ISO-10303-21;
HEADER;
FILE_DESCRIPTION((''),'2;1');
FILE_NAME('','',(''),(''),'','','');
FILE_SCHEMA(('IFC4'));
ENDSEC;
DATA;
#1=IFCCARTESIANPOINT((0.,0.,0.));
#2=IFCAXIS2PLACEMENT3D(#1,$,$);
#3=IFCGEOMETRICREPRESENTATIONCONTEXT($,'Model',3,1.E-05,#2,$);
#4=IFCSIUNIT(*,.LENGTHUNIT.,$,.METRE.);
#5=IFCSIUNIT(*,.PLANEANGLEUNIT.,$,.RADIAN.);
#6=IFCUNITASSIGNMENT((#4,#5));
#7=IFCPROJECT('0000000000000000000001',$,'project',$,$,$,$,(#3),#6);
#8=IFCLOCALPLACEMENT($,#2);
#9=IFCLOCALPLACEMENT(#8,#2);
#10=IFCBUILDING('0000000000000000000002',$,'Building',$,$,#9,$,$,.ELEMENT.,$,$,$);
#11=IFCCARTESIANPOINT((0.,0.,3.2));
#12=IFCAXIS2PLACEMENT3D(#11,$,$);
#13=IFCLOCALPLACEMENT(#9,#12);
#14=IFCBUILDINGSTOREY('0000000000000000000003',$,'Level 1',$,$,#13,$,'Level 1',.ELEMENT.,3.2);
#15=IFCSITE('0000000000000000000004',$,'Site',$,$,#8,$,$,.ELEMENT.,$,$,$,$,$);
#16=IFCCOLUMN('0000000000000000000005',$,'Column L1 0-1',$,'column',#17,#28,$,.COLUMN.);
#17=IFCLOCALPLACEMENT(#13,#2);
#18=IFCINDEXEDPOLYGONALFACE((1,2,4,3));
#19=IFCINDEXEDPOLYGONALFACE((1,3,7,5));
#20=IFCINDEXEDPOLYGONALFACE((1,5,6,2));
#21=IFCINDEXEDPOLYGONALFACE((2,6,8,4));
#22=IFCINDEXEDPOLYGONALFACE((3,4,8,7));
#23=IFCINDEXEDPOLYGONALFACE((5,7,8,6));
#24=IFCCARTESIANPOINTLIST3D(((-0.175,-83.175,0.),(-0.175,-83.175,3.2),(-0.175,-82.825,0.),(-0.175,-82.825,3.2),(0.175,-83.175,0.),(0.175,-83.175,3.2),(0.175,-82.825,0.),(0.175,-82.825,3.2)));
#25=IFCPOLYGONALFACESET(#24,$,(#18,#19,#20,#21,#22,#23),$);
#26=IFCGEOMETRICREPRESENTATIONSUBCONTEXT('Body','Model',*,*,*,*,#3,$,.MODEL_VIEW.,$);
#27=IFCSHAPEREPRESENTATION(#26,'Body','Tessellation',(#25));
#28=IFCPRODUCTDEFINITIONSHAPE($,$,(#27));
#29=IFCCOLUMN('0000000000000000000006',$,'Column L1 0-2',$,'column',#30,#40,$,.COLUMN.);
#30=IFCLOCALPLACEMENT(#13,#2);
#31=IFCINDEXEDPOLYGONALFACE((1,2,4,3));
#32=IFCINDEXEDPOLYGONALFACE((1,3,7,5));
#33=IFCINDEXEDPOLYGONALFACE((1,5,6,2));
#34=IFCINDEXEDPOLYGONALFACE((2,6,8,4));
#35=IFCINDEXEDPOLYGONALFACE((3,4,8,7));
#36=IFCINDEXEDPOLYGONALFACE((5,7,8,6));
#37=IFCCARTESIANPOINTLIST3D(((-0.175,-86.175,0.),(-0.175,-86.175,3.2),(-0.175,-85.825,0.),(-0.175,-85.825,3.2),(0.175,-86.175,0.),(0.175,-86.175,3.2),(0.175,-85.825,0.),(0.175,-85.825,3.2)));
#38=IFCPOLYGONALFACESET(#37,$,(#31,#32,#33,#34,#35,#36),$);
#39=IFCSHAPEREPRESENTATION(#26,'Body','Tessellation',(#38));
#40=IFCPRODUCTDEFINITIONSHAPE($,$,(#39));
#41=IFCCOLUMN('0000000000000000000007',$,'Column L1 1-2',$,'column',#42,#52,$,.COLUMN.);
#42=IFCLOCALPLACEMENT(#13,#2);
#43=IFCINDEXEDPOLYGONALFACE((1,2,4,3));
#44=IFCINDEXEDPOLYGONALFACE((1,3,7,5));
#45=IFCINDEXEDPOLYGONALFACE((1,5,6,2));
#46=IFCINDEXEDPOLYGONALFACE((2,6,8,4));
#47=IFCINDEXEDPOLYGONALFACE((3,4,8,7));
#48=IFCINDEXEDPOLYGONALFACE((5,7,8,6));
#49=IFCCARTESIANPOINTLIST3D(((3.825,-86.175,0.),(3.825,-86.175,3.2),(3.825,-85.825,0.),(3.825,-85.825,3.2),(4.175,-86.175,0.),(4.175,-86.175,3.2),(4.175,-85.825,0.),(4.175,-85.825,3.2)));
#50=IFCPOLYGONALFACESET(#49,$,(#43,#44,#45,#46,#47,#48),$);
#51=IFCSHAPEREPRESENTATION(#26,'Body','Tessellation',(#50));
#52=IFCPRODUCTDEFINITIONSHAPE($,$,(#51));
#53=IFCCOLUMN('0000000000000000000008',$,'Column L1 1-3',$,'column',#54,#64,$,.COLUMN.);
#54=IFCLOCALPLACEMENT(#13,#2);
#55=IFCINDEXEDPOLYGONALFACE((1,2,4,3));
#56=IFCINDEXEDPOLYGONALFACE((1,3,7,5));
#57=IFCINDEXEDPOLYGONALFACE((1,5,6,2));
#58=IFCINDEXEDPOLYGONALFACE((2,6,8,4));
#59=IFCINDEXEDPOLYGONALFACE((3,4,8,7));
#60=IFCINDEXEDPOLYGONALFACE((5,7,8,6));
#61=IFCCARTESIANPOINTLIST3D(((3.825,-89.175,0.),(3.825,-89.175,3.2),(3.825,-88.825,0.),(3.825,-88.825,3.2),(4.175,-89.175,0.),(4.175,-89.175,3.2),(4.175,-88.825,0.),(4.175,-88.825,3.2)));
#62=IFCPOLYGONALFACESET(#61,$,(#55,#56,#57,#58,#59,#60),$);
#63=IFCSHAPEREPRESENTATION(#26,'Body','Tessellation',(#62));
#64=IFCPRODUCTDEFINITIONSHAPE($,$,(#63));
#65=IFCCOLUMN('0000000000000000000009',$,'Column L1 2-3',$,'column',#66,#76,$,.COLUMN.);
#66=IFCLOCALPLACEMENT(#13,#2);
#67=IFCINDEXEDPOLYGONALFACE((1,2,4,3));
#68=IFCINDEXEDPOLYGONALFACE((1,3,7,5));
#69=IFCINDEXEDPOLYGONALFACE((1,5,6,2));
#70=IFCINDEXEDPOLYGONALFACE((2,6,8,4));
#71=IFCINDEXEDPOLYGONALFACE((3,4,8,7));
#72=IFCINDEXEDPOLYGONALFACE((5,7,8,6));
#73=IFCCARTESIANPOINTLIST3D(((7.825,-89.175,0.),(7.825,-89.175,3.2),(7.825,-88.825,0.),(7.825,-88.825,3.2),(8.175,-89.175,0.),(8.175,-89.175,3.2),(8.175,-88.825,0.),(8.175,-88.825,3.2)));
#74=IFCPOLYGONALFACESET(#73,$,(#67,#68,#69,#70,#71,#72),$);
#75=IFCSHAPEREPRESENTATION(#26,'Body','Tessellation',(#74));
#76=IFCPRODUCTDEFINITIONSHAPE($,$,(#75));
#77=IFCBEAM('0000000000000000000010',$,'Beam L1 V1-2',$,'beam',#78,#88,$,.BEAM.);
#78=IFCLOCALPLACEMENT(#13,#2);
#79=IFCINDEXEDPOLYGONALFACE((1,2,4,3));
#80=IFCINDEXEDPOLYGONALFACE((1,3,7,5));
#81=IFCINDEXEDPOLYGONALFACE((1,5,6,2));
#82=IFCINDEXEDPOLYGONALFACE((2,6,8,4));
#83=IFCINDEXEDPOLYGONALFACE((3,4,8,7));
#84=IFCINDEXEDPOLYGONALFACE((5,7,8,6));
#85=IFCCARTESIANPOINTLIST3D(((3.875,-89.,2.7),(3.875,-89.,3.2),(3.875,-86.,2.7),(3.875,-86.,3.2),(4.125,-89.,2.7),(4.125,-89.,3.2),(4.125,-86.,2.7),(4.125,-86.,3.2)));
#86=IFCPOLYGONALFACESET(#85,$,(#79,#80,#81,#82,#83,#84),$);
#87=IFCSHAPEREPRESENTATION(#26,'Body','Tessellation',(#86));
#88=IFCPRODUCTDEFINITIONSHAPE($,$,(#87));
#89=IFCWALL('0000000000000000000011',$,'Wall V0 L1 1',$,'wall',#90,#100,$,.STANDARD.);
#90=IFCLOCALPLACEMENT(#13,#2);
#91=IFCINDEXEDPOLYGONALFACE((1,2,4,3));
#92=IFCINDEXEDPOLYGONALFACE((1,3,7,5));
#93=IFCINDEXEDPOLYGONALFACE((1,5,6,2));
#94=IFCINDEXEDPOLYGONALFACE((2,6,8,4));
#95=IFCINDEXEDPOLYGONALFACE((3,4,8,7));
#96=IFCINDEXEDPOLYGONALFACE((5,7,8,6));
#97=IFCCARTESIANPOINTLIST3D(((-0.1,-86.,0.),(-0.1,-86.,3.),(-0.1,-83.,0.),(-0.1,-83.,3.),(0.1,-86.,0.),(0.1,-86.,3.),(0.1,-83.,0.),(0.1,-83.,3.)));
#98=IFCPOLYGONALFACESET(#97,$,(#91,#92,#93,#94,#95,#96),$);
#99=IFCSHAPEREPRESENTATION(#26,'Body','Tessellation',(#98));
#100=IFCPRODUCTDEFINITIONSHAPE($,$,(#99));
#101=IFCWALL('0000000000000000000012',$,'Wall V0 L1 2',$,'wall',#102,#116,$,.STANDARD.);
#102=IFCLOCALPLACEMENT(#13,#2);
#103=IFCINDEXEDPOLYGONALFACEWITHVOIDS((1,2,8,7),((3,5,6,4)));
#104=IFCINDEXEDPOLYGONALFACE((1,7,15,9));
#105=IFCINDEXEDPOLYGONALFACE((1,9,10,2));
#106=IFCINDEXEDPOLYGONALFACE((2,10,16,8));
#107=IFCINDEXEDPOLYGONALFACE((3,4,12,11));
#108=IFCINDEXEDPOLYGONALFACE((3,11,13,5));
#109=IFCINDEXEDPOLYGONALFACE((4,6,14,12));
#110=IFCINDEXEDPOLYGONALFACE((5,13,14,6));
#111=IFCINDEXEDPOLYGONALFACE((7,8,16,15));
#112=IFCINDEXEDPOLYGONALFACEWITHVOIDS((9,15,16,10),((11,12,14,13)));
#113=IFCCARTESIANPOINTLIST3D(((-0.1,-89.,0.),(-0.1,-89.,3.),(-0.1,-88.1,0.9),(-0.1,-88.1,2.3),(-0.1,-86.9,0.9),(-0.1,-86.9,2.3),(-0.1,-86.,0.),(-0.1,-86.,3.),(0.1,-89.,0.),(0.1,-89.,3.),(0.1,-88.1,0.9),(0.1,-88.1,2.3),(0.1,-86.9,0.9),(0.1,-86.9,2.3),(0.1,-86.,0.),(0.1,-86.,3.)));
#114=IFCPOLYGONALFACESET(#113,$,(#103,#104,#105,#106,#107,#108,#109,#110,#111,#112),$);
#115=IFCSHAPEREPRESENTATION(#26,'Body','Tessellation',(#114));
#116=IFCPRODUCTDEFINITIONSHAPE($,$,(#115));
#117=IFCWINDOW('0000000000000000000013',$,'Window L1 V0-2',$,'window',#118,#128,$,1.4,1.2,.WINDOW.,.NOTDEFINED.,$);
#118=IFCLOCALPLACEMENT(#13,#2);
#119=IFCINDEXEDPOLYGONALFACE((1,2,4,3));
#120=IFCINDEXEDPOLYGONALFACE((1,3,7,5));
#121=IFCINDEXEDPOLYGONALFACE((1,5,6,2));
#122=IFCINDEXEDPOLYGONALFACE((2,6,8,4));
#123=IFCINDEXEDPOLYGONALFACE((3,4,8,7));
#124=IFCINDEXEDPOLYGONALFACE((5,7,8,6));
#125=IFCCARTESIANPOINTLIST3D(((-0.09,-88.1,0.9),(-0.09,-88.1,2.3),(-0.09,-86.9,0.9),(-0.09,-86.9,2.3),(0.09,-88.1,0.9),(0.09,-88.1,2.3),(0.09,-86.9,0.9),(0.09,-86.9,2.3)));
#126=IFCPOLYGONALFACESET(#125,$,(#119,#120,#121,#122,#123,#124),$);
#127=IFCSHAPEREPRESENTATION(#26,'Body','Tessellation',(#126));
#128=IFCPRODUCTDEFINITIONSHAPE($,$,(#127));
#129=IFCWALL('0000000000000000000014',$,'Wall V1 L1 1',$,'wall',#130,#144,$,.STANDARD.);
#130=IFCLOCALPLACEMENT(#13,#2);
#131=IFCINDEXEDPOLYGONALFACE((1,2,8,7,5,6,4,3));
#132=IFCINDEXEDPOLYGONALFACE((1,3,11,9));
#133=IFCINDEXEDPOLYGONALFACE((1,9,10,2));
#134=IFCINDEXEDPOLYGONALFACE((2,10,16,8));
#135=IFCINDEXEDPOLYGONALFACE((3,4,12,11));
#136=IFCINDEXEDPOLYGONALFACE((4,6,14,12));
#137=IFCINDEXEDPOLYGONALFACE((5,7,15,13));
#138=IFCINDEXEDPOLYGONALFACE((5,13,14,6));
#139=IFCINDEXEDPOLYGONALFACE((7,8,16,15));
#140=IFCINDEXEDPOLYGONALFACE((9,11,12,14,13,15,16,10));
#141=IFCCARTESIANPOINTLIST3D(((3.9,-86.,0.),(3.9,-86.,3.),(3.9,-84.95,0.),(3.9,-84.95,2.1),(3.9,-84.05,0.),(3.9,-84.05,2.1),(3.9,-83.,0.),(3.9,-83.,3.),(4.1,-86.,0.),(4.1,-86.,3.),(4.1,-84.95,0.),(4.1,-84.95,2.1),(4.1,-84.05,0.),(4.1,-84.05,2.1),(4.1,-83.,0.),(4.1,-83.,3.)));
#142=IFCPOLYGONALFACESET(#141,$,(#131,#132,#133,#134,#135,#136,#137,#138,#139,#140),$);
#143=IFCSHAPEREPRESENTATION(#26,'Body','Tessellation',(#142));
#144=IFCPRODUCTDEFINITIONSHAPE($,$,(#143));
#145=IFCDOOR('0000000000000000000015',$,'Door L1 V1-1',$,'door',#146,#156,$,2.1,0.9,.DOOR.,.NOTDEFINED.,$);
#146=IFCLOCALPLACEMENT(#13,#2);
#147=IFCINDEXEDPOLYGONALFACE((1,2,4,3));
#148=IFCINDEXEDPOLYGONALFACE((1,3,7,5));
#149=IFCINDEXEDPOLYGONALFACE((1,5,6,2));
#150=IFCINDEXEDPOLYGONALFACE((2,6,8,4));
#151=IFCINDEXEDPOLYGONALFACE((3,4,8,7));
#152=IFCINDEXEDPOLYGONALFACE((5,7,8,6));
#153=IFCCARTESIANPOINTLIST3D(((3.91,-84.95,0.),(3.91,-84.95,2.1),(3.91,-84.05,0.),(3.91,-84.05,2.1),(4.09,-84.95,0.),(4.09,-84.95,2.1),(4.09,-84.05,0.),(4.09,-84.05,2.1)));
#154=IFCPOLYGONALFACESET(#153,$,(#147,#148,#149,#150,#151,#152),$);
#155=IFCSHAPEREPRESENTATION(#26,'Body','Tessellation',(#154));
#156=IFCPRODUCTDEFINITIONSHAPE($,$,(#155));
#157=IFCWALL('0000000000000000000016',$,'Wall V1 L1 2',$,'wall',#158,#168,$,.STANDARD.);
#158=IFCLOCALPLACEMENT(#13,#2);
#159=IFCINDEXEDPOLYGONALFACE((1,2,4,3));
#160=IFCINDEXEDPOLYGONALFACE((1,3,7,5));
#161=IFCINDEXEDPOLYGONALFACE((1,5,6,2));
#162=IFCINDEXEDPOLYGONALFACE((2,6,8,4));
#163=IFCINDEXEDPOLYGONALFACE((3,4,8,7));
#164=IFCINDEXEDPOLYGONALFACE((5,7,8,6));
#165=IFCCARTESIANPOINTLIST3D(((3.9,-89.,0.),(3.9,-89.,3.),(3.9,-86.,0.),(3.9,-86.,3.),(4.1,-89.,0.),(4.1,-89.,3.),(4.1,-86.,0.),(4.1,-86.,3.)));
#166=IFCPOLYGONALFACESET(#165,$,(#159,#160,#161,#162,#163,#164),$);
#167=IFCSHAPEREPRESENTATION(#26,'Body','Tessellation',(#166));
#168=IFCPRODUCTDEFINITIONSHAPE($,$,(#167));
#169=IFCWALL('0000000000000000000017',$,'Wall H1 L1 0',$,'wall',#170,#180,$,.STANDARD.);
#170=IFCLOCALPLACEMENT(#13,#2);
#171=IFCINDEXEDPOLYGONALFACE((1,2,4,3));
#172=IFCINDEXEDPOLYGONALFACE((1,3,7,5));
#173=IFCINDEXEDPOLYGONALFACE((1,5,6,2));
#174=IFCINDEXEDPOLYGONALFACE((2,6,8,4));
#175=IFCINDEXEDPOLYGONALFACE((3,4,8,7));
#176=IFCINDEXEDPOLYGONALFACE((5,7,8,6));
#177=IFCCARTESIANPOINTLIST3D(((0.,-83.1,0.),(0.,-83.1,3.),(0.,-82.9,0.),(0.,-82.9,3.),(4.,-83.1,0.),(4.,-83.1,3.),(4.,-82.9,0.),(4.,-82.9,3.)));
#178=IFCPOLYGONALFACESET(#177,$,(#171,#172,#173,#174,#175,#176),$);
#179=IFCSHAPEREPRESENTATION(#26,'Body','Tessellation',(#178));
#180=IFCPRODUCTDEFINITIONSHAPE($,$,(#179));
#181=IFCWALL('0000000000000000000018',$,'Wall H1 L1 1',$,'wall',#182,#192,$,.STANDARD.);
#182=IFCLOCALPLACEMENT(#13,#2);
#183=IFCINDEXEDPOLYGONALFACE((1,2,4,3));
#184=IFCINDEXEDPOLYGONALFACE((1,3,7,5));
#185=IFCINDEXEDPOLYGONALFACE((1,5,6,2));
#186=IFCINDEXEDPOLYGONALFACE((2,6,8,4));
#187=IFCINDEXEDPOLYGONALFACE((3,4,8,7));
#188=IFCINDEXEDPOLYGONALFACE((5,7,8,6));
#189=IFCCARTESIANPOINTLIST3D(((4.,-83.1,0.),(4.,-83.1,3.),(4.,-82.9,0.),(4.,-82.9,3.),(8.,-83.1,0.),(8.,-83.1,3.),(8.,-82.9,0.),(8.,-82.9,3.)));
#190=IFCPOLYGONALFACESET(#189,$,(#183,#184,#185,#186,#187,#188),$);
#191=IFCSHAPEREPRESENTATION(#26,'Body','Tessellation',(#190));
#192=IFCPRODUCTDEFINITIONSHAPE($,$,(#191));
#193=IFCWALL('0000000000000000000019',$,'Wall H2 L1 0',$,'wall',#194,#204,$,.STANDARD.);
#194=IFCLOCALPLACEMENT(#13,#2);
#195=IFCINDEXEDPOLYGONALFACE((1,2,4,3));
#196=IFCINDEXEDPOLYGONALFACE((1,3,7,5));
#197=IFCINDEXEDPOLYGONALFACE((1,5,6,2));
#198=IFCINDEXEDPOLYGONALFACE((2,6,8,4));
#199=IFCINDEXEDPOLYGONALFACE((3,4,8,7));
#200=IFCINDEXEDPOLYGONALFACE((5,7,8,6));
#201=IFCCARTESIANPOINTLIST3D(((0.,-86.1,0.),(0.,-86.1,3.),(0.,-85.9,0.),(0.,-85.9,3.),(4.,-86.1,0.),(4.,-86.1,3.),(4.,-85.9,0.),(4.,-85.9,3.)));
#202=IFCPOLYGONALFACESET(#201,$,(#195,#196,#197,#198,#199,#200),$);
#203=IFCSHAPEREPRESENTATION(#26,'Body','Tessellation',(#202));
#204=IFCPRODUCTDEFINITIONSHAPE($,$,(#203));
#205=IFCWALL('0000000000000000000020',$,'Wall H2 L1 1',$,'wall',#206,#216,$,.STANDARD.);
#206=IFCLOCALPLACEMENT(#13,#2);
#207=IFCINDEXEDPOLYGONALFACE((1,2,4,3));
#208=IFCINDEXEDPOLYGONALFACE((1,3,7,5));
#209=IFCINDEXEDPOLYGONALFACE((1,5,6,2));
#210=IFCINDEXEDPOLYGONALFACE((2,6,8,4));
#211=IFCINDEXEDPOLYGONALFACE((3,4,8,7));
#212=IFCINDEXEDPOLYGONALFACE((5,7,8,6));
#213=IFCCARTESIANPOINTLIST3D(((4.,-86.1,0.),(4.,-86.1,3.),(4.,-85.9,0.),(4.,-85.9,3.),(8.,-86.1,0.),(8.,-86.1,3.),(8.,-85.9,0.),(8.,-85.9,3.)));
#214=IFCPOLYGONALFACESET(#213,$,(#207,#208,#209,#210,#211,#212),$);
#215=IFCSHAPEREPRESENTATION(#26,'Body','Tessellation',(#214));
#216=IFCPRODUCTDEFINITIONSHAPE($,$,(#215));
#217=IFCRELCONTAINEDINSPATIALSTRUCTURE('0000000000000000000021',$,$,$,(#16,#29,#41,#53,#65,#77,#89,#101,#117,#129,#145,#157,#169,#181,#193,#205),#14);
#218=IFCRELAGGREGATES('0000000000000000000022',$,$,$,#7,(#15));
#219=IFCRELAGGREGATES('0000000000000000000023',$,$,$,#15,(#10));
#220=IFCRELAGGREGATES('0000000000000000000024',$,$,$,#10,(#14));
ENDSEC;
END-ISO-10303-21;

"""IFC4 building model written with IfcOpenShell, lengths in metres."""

from ifc_helpers import new_model, si_unit, frame, frame_2d, origin, origin_2d, place, context, subcontext, project, spatial, rectangle, extrude, element, fill, save


model = new_model("IFC4")

# Units and contexts
model_context = context("Model", 3, precision=1e-05, world=origin())
body_context = subcontext(model_context, "Body", "Model", "MODEL_VIEW")
ifc_project = project(units=[si_unit("LENGTHUNIT", "METRE"), si_unit("PLANEANGLEUNIT", "RADIAN")], contexts=[model_context])

# Site, building, storey
site_placement = place(None, origin())
site = spatial("IfcSite", under=ifc_project, at=site_placement, Name="Site", CompositionType="ELEMENT")
building_placement = place(site_placement, origin())
building = spatial("IfcBuilding", under=site, at=building_placement, Name="Building", CompositionType="ELEMENT")
storey_placement = place(building_placement, frame((0.0, 0.0, 3.2)))
storey = spatial("IfcBuildingStorey", under=building, at=storey_placement, Name="Level 1", LongName="Level 1", CompositionType="ELEMENT", Elevation=3.2)

# Columns
for number, where, name in (
    (1, (0.0, -83.0, 0.0), "Column L1 0-1"),
    (2, (0.0, -86.0, 0.0), "Column L1 0-2"),
    (3, (4.0, -86.0, 0.0), "Column L1 1-2"),
    (4, (4.0, -89.0, 0.0), "Column L1 1-3"),
    (5, (8.0, -89.0, 0.0), "Column L1 2-3"),
):
    element("IfcColumn", number, at=place(storey_placement, frame(where)), inside=storey, Name=name, ObjectType="column", PredefinedType="COLUMN", context=body_context, shape_type="SweptSolid", body=[
        extrude(rectangle(XDim=0.35, YDim=0.35, at=origin_2d()), origin(), (0.0, 0.0, 1.0), 3.2),
    ])

# Beam
beam_placement = place(storey_placement, frame((4.0, -86.0, 2.95), z_axis=(0.0, -1.0, 0.0), x_axis=(0.0, 0.0, 1.0)))
element("IfcBeam", 6, at=beam_placement, inside=storey, Name="Beam L1 V1-2", ObjectType="beam", PredefinedType="BEAM", context=body_context, shape_type="SweptSolid", body=[
    extrude(rectangle(XDim=0.5, YDim=0.25, at=origin_2d()), origin(), (0.0, 0.0, 1.0), 3.0),
])

# Wall
wall_1_placement = place(storey_placement, frame((0.0, -83.0, 0.0), z_axis=(0.0, 0.0, 1.0), x_axis=(0.0, -1.0, 0.0)))
element("IfcWall", 7, at=wall_1_placement, inside=storey, Name="Wall V0 L1 1", ObjectType="wall", PredefinedType="STANDARD", context=body_context, shape_type="SweptSolid", body=[
    extrude(rectangle(XDim=3.0, YDim=0.2, at=frame_2d((1.5, 0.0))), origin(), (0.0, 0.0, 1.0), 3.0),
])

# Wall, opening, window
wall_2_placement = place(storey_placement, frame((0.0, -86.0, 0.0), z_axis=(0.0, 0.0, 1.0), x_axis=(0.0, -1.0, 0.0)))
wall_2 = element("IfcWall", 8, at=wall_2_placement, inside=storey, Name="Wall V0 L1 2", ObjectType="wall", PredefinedType="STANDARD", context=body_context, shape_type="SweptSolid", body=[
    extrude(rectangle(XDim=3.0, YDim=0.2, at=frame_2d((1.5, 0.0))), origin(), (0.0, 0.0, 1.0), 3.0),
])
opening_1_placement = place(storey_placement, frame((0.0, -87.5, 0.9), z_axis=(0.0, 0.0, 1.0), x_axis=(0.0, -1.0, 0.0)))
opening_1 = element("IfcOpeningElement", 9, at=opening_1_placement, cuts=wall_2, ObjectType="Opening", PredefinedType="OPENING", context=body_context, shape_type="SweptSolid", body=[
    extrude(rectangle(XDim=1.2, YDim=0.22, at=origin_2d()), origin(), (0.0, 0.0, 1.0), 1.4),
])
window_1_placement = place(storey_placement, frame((0.0, -87.5, 0.9), z_axis=(0.0, 0.0, 1.0), x_axis=(0.0, -1.0, 0.0)))
window_1 = element("IfcWindow", 10, at=window_1_placement, inside=storey, Name="Window L1 V0-2", ObjectType="window", OverallHeight=1.4, OverallWidth=1.2, PartitioningType="NOTDEFINED", PredefinedType="WINDOW", context=body_context, shape_type="SweptSolid", body=[
    extrude(rectangle(XDim=1.2, YDim=0.18, at=origin_2d()), origin(), (0.0, 0.0, 1.0), 1.4),
])
fill(opening_1, window_1)

# Wall, opening, door
wall_3_placement = place(storey_placement, frame((4.0, -83.0, 0.0), z_axis=(0.0, 0.0, 1.0), x_axis=(0.0, -1.0, 0.0)))
wall_3 = element("IfcWall", 11, at=wall_3_placement, inside=storey, Name="Wall V1 L1 1", ObjectType="wall", PredefinedType="STANDARD", context=body_context, shape_type="SweptSolid", body=[
    extrude(rectangle(XDim=3.0, YDim=0.2, at=frame_2d((1.5, 0.0))), origin(), (0.0, 0.0, 1.0), 3.0),
])
opening_2_placement = place(storey_placement, frame((4.0, -84.5, 0.0), z_axis=(0.0, 0.0, 1.0), x_axis=(0.0, -1.0, 0.0)))
opening_2 = element("IfcOpeningElement", 12, at=opening_2_placement, cuts=wall_3, ObjectType="Opening", PredefinedType="OPENING", context=body_context, shape_type="SweptSolid", body=[
    extrude(rectangle(XDim=0.9, YDim=0.22, at=origin_2d()), origin(), (0.0, 0.0, 1.0), 2.1),
])
door_placement = place(storey_placement, frame((4.0, -84.5, 0.0), z_axis=(0.0, 0.0, 1.0), x_axis=(0.0, -1.0, 0.0)))
door = element("IfcDoor", 13, at=door_placement, inside=storey, Name="Door L1 V1-1", ObjectType="door", OperationType="NOTDEFINED", OverallHeight=2.1, OverallWidth=0.9, PredefinedType="DOOR", context=body_context, shape_type="SweptSolid", body=[
    extrude(rectangle(XDim=0.9, YDim=0.18, at=origin_2d()), origin(), (0.0, 0.0, 1.0), 2.1),
])
fill(opening_2, door)

# Walls
wall_4_placement = place(storey_placement, frame((4.0, -86.0, 0.0), z_axis=(0.0, 0.0, 1.0), x_axis=(0.0, -1.0, 0.0)))
element("IfcWall", 14, at=wall_4_placement, inside=storey, Name="Wall V1 L1 2", ObjectType="wall", PredefinedType="STANDARD", context=body_context, shape_type="SweptSolid", body=[
    extrude(rectangle(XDim=3.0, YDim=0.2, at=frame_2d((1.5, 0.0))), origin(), (0.0, 0.0, 1.0), 3.0),
])
for number, where, z_axis, x_axis, name in (
    (15, (0.0, -83.0, 0.0), (0.0, 0.0, 1.0), (1.0, 0.0, 0.0), "Wall H1 L1 0"),
    (16, (4.0, -83.0, 0.0), (0.0, 0.0, 1.0), (1.0, 0.0, 0.0), "Wall H1 L1 1"),
    (17, (0.0, -86.0, 0.0), (0.0, 0.0, 1.0), (1.0, 0.0, 0.0), "Wall H2 L1 0"),
    (18, (4.0, -86.0, 0.0), (0.0, 0.0, 1.0), (1.0, 0.0, 0.0), "Wall H2 L1 1"),
):
    element("IfcWall", number, at=place(storey_placement, frame(where, z_axis=z_axis, x_axis=x_axis)), inside=storey, Name=name, ObjectType="wall", PredefinedType="STANDARD", context=body_context, shape_type="SweptSolid", body=[
        extrude(rectangle(XDim=4.0, YDim=0.2, at=frame_2d((2.0, 0.0))), origin(), (0.0, 0.0, 1.0), 3.0),
    ])

save(model, "model.ifc")
